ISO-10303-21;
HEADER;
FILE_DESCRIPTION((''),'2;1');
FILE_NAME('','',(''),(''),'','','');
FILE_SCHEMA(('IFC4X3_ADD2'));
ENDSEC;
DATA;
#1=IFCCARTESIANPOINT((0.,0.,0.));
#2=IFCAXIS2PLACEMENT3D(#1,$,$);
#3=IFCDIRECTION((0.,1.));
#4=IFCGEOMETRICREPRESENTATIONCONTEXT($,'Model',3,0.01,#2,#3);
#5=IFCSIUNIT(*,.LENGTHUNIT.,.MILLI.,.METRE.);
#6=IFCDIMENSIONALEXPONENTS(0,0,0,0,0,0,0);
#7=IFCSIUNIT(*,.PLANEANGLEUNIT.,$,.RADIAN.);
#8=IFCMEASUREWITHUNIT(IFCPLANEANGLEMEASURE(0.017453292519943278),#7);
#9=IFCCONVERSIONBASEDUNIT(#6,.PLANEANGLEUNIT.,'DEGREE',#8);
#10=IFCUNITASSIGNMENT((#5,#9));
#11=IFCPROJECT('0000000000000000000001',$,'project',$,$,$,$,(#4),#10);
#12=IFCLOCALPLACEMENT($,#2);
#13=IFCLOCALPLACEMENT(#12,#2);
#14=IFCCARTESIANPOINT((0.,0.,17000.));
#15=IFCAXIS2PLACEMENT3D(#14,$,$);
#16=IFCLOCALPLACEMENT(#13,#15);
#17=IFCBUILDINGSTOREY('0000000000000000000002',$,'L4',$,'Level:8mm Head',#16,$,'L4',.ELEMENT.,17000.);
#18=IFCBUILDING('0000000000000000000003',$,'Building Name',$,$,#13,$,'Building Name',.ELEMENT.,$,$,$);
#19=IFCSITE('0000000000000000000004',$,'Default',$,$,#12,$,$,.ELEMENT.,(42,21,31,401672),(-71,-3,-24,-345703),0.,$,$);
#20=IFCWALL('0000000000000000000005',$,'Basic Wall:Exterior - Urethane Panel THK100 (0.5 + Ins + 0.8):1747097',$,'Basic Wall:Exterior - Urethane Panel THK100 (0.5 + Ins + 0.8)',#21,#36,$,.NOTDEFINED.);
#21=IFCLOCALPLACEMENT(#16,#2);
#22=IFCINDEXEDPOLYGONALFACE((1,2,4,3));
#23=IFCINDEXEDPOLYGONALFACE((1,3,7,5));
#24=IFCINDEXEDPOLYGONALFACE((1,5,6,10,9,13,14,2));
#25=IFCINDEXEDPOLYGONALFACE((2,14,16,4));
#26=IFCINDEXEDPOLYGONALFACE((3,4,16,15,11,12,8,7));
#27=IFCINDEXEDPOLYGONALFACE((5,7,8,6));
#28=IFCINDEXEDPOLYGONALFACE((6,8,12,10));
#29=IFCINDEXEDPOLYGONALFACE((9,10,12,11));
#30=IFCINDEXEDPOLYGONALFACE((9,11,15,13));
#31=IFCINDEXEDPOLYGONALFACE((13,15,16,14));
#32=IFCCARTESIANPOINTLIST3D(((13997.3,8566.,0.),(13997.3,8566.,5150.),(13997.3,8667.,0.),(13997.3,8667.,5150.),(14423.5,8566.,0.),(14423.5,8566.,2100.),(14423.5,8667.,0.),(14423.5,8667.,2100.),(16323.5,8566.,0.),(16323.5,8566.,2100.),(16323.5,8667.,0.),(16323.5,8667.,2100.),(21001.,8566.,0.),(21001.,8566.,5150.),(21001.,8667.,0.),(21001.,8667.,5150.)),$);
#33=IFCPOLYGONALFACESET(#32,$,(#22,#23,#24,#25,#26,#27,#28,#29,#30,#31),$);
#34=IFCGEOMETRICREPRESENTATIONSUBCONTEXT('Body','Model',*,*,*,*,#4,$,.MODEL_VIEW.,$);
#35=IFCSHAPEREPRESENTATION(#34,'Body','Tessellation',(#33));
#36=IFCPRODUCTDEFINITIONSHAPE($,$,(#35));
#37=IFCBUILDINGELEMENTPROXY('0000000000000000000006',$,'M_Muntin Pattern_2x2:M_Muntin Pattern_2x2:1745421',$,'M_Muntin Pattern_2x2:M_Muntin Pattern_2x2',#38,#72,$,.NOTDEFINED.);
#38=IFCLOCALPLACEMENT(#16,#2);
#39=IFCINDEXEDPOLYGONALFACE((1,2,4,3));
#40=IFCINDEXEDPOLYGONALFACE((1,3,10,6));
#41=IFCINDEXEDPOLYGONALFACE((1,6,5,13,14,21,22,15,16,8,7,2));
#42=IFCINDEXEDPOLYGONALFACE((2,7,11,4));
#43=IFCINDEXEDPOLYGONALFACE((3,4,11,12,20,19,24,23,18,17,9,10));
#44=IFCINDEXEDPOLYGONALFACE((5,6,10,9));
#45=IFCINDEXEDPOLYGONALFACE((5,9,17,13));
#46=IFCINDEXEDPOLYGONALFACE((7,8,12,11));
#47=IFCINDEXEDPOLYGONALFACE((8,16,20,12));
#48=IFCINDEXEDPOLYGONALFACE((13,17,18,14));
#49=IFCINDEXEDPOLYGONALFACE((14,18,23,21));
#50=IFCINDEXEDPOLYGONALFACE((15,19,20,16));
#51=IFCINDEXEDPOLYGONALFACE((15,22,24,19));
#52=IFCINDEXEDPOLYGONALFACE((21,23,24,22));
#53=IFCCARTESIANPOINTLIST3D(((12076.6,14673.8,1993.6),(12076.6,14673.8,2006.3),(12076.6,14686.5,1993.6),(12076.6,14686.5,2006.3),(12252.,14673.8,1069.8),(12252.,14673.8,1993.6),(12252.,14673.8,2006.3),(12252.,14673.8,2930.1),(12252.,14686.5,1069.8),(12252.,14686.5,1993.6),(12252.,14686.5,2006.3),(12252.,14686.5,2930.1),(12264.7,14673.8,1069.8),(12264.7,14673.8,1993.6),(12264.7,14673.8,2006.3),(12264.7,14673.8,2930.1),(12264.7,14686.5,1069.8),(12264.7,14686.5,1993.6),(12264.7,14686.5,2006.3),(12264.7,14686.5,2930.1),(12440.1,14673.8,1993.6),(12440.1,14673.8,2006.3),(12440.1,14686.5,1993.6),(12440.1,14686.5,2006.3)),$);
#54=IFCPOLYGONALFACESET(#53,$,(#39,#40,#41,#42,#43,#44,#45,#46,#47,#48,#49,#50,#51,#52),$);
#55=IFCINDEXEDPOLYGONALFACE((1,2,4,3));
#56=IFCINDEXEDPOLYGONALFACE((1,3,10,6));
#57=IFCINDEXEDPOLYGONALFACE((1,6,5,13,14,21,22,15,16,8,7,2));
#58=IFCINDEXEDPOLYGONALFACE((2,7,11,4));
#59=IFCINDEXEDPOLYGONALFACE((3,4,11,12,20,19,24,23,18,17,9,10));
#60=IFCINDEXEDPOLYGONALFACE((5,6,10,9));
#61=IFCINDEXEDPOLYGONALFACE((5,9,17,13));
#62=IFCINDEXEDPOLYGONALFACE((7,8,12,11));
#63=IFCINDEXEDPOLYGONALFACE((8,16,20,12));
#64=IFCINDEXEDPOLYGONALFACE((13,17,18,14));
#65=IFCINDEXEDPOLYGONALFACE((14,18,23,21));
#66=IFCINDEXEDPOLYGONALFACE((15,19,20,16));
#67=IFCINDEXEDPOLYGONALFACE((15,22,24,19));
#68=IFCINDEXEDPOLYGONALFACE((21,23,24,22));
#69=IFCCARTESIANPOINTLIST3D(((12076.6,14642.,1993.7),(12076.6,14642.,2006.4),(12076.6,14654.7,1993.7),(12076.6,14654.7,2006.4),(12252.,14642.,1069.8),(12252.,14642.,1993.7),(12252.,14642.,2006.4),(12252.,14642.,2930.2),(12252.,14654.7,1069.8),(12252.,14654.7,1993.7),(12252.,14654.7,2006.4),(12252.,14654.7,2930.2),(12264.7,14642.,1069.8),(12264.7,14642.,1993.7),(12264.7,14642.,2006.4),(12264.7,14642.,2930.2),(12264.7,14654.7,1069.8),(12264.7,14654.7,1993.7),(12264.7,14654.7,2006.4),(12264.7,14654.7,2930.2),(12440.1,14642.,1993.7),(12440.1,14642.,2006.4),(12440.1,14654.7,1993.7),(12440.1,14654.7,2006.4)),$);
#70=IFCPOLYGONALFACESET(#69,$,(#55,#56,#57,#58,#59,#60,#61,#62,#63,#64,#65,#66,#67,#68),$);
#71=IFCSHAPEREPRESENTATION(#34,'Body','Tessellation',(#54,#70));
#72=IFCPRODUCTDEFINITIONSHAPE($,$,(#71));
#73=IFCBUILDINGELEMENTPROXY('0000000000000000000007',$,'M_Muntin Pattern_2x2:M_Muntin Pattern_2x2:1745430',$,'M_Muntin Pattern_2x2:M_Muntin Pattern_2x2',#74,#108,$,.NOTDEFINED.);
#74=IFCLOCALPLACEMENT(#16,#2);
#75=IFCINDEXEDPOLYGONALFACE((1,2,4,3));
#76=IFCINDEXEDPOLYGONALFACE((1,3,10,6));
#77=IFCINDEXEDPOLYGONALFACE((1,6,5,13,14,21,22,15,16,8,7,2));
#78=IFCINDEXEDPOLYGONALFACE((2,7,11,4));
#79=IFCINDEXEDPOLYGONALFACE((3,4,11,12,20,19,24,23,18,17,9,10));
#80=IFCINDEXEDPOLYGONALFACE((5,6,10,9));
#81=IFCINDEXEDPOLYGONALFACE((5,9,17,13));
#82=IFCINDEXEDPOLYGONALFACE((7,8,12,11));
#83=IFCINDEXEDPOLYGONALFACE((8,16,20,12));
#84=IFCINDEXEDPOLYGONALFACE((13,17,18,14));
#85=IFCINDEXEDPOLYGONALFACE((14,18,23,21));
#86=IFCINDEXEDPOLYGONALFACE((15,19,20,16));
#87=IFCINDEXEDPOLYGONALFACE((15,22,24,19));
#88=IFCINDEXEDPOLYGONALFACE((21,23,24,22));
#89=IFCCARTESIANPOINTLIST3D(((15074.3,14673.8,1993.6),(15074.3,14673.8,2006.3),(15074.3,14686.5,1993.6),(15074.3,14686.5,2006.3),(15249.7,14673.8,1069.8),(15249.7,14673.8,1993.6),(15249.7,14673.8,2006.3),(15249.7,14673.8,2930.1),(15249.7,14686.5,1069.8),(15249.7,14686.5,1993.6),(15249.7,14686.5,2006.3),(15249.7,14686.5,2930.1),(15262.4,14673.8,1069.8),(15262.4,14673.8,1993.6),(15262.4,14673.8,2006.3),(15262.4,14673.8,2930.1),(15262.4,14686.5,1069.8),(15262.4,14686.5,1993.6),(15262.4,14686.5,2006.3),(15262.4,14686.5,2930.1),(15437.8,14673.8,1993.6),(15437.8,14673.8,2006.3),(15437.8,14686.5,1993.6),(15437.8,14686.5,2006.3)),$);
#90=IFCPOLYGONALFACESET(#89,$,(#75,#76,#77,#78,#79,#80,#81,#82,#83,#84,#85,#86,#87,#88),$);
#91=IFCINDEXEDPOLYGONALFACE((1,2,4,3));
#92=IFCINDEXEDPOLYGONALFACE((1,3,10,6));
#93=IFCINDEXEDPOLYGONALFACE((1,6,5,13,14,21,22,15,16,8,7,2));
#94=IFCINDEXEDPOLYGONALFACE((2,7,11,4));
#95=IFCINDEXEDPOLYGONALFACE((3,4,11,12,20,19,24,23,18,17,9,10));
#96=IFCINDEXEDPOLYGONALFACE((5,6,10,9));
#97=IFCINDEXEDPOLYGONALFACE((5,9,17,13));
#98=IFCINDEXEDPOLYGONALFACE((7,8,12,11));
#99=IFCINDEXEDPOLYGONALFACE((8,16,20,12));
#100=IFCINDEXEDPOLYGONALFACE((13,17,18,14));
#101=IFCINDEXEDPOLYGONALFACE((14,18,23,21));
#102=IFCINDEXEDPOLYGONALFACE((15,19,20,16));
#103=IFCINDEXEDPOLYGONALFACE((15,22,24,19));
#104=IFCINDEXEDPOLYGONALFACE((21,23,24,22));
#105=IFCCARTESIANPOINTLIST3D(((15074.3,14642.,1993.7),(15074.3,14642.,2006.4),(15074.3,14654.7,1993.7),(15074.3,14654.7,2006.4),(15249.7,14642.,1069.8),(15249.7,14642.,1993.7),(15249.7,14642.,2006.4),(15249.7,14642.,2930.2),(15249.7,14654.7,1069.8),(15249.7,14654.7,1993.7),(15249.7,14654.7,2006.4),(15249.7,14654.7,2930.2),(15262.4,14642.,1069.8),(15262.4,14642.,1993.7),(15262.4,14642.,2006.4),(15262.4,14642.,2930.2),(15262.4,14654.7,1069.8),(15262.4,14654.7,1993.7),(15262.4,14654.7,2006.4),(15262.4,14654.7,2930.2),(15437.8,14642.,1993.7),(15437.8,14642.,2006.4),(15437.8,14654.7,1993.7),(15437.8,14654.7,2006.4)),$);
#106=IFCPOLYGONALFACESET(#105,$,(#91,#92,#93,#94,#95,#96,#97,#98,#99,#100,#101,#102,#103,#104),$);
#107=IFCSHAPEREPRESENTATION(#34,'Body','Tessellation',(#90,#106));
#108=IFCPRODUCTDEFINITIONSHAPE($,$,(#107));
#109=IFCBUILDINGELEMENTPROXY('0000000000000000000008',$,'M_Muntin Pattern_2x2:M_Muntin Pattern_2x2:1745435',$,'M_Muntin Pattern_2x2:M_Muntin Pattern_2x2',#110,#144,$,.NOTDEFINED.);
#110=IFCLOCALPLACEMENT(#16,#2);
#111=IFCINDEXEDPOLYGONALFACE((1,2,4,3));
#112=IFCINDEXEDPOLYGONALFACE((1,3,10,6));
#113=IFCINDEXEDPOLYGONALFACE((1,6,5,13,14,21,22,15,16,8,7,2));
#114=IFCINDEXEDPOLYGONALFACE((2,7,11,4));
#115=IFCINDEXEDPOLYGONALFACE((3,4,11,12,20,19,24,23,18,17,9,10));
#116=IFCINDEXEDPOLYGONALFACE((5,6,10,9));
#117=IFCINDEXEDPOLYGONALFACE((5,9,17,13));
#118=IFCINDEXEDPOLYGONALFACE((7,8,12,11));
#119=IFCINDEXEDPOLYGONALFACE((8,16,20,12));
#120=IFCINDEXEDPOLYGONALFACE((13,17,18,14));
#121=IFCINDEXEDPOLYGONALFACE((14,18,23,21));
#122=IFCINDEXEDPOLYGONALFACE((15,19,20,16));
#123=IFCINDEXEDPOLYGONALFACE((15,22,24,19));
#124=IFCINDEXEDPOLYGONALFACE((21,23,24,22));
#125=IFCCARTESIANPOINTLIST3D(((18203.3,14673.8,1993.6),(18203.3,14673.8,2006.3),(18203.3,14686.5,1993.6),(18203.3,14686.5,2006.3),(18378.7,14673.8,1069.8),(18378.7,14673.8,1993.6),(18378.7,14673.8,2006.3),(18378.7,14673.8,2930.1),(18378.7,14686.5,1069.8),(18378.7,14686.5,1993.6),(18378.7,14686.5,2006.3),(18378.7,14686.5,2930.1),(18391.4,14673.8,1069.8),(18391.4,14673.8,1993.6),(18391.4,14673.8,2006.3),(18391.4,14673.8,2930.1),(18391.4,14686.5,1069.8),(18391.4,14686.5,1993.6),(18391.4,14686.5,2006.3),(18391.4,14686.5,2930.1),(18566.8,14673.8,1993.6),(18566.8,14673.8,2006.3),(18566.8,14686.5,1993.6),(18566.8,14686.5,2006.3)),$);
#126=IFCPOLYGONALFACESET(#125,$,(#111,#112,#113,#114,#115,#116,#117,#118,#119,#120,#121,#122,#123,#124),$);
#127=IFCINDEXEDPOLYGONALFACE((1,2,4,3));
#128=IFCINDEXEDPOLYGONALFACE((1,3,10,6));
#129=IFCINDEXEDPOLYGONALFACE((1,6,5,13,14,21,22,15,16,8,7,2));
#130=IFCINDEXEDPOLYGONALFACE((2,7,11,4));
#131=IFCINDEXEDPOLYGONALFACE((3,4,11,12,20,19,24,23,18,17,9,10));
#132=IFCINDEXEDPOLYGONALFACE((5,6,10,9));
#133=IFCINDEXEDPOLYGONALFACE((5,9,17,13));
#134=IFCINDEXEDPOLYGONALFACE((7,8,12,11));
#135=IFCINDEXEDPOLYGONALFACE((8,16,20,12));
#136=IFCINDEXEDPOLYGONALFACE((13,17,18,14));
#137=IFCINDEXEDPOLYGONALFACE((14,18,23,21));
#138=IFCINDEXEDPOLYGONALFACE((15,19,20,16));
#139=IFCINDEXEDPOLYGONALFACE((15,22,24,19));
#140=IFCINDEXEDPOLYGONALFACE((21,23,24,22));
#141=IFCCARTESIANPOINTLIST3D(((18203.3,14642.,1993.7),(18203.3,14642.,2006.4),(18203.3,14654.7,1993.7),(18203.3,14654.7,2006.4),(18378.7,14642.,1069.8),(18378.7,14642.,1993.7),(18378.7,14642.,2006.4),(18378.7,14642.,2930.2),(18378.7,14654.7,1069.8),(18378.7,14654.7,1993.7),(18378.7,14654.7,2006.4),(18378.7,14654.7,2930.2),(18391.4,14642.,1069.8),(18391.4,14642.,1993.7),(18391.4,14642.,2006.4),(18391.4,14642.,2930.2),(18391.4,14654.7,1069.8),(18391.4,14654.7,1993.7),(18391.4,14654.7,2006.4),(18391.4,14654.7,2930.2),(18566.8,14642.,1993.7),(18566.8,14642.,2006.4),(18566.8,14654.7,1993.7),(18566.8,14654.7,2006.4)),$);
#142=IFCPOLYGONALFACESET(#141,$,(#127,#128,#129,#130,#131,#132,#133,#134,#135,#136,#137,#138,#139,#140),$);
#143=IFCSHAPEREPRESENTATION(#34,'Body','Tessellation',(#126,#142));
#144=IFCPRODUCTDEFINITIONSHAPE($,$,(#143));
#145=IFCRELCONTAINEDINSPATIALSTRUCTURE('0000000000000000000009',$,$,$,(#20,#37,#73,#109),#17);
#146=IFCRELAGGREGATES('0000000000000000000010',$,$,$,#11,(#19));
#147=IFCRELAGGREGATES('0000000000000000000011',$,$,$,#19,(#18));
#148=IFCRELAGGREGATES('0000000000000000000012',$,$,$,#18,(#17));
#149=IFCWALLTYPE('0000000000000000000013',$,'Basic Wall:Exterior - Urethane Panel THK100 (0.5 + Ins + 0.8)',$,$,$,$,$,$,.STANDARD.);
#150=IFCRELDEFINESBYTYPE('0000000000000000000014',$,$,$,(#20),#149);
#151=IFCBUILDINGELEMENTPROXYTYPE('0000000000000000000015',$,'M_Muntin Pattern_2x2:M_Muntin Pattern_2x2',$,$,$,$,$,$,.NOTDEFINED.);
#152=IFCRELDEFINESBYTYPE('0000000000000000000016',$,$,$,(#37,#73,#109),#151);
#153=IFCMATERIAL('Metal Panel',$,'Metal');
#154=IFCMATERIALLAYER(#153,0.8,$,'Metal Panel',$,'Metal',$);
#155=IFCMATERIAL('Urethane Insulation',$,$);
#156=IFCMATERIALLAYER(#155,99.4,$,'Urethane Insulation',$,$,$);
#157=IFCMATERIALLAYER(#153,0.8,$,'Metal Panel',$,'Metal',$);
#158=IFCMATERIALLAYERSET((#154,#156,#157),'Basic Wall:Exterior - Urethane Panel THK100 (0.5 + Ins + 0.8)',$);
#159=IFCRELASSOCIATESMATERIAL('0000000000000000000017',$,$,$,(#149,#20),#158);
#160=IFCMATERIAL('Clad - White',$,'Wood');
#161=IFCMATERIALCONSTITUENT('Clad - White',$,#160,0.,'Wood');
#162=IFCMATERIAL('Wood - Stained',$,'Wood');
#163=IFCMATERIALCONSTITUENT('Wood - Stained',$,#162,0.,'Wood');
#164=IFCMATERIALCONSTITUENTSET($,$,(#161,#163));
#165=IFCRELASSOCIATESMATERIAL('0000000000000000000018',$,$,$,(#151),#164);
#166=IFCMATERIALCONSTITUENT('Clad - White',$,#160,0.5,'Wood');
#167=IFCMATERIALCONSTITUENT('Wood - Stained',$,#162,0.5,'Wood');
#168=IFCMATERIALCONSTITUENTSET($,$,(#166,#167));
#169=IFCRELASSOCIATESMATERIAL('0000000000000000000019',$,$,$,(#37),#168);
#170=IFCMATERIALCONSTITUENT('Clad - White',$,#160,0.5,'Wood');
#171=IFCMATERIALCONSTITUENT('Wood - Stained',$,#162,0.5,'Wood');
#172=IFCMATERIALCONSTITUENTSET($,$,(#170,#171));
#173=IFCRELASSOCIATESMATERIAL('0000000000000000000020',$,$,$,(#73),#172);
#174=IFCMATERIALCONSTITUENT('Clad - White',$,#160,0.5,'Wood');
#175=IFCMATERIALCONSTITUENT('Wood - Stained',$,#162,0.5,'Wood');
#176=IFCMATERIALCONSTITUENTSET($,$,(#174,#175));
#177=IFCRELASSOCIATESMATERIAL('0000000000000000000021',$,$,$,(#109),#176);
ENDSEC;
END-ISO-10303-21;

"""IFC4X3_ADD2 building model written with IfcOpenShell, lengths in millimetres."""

from ifc_helpers import new_model, entity, si_unit, converted_unit, direction, frame, frame_2d, origin, place, context, subcontext, project, spatial, polyline, rectangle, outline, extrude, clip, bounded_halfspace, source, transform, mapped, material, layer, layer_set, constituent, constituent_set, type_object, type_shapes, element, save


model = new_model("IFC4X3_ADD2")

# Units and contexts
model_context = context("Model", 3, precision=0.01, world=origin(), true_north=direction((0.0, 1.0)))
body_context = subcontext(model_context, "Body", "Model", "MODEL_VIEW")
ifc_project = project(units=[si_unit("LENGTHUNIT", "METRE", prefix="MILLI"), converted_unit("PLANEANGLEUNIT", "DEGREE", entity("IfcPlaneAngleMeasure", 0.017453292519943278), si_unit("PLANEANGLEUNIT", "RADIAN"), dimensions=[0, 0, 0, 0, 0, 0, 0])], contexts=[model_context])

# Site, building, storey
site_placement = place(None, origin())
site = spatial("IfcSite", under=ifc_project, at=site_placement, Name="Default", CompositionType="ELEMENT", RefLatitude=(42, 21, 31, 401672), RefLongitude=(-71, -3, -24, -345703), RefElevation=0.0)
building_placement = place(site_placement, origin())
building = spatial("IfcBuilding", under=site, at=building_placement, Name="Building Name", LongName="Building Name", CompositionType="ELEMENT")
storey_placement = place(building_placement, frame((0.0, 0.0, 17000.0)))
storey = spatial("IfcBuildingStorey", under=building, at=storey_placement, Name="L4", ObjectType="Level:8mm Head", LongName="L4", CompositionType="ELEMENT", Elevation=17000.0)

# Shared definitions
ifc_material_1 = material(Name="Metal Panel", Category="Metal")
ifc_layer_1 = layer(ifc_material_1, 0.8, Name="Metal Panel", Category="Metal")
ifc_material_2 = material(Name="Urethane Insulation")
ifc_layer_2 = layer(ifc_material_2, 99.4, Name="Urethane Insulation")
ifc_layer_3 = layer(ifc_material_1, 0.8, Name="Metal Panel", Category="Metal")
ifc_layer_set_1 = layer_set([ifc_layer_1, ifc_layer_2, ifc_layer_3], Name="Basic Wall:Exterior - Urethane Panel THK100 (0.5 + Ins + 0.8)")
wall_type = type_object("IfcWallType", Name="Basic Wall:Exterior - Urethane Panel THK100 (0.5 + Ins + 0.8)", PredefinedType="STANDARD", material=ifc_layer_set_1)

# Wall, opening
wall_1_placement = place(storey_placement, frame((13997.3, 8616.5, 0.0)))
wall_1 = element("IfcWall", 1, at=wall_1_placement, inside=storey, type_object=wall_type, material=ifc_layer_set_1, Name="Basic Wall:Exterior - Urethane Panel THK100 (0.5 + Ins + 0.8):1747097", ObjectType="Basic Wall:Exterior - Urethane Panel THK100 (0.5 + Ins + 0.8)", PredefinedType="NOTDEFINED", context=body_context, shape_type="Clipping", body=[
    clip(extrude(rectangle(XDim=7003.7, YDim=101.0, at=frame_2d((3501.8, 0.0), x_axis=(-1.0, 0.0))), origin(), (0.0, 0.0, 1.0), 5150.0), bounded_halfspace(frame((0.0, -50.5, 5150.0), z_axis=(0.0, 0.0, -1.0), x_axis=(0.0, 1.0, 0.0)), True, frame((0.0, -50.5, 5150.0)), polyline([(0.0, 0.0), (7003.7, 0.0), (7003.7, 101.0), (0.0, 101.0), (0.0, 0.0)]))),
])
opening_1_placement = place(wall_1_placement, frame((2326.2, 50.5, 0.0)))
element("IfcOpeningElement", 2, at=opening_1_placement, cuts=wall_1, PredefinedType="OPENING", context=body_context, shape_type="SweptSolid", body=[
    extrude(rectangle(XDim=2100.0, YDim=1900.0, at=frame_2d((1050.0, 950.0), x_axis=(1.0, 0.0))), frame((0.0, 0.0, 0.0), z_axis=(0.0, -1.0, 0.0), x_axis=(0.0, 0.0, 1.0)), (0.0, 0.0, 1.0), 101.0),
])

# Building element proxies
ifc_material_3 = material(Name="Clad - White", Category="Wood")
ifc_constituent_1 = constituent(ifc_material_3, Name="Clad - White", Category="Wood", fraction=0.5)
ifc_material_4 = material(Name="Wood - Stained", Category="Wood")
ifc_constituent_2 = constituent(ifc_material_4, Name="Wood - Stained", Category="Wood", fraction=0.5)
ifc_constituent_set_1 = constituent_set(constituents=[ifc_constituent_1, ifc_constituent_2])
ifc_constituent_3 = constituent(ifc_material_3, Name="Clad - White", Category="Wood", fraction=0.0)
ifc_constituent_4 = constituent(ifc_material_4, Name="Wood - Stained", Category="Wood", fraction=0.0)
ifc_constituent_set_2 = constituent_set(constituents=[ifc_constituent_3, ifc_constituent_4])
building_element_proxy_type_1 = type_object("IfcBuildingElementProxyType", Name="M_Muntin Pattern_2x2:M_Muntin Pattern_2x2", PredefinedType="NOTDEFINED", material=ifc_constituent_set_2)
shared_shape_1 = source(origin(), body_context, "Body", "SweptSolid", [
    extrude(outline(polyline([(6.4, -6.4), (930.1, -6.4), (930.1, 6.3), (6.4, 6.3), (6.4, 181.7), (-6.3, 181.7), (-6.3, 6.3), (-930.2, 6.3), (-930.2, -6.4), (-6.3, -6.4), (-6.3, -181.7), (6.4, -181.7), (6.4, -6.4)])), frame((0.0, 9.5, 930.1), z_axis=(0.0, 1.0, 0.0), x_axis=(0.0, 0.0, 1.0)), (0.0, 0.0, 1.0), 12.7),
    extrude(outline(polyline([(6.4, -6.4), (930.2, -6.4), (930.2, 6.3), (6.4, 6.3), (6.4, 181.7), (-6.3, 181.7), (-6.3, 6.3), (-930.2, 6.3), (-930.2, -6.4), (-6.3, -6.4), (-6.3, -181.7), (6.4, -181.7), (6.4, -6.4)])), frame((0.0, -22.2, 930.2), z_axis=(0.0, 1.0, 0.0), x_axis=(0.0, 0.0, 1.0)), (0.0, 0.0, 1.0), 12.7),
])
type_shapes(building_element_proxy_type_1, [shared_shape_1])
proxy_1_placement = place(storey_placement, frame((12258.4, 14664.3, 1069.8)))
element("IfcBuildingElementProxy", 3, at=proxy_1_placement, inside=storey, type_object=building_element_proxy_type_1, material=ifc_constituent_set_1, Name="M_Muntin Pattern_2x2:M_Muntin Pattern_2x2:1745421", ObjectType="M_Muntin Pattern_2x2:M_Muntin Pattern_2x2", PredefinedType="NOTDEFINED", context=body_context, shape_type="MappedRepresentation", body=[
    mapped(shared_shape_1, transform((0.0, 0.0, 0.0), scale=1.0)),
])
ifc_constituent_5 = constituent(ifc_material_3, Name="Clad - White", Category="Wood", fraction=0.5)
ifc_constituent_6 = constituent(ifc_material_4, Name="Wood - Stained", Category="Wood", fraction=0.5)
ifc_constituent_set_3 = constituent_set(constituents=[ifc_constituent_5, ifc_constituent_6])
proxy_2_placement = place(storey_placement, frame((15256.0, 14664.3, 1069.8)))
element("IfcBuildingElementProxy", 4, at=proxy_2_placement, inside=storey, type_object=building_element_proxy_type_1, material=ifc_constituent_set_3, Name="M_Muntin Pattern_2x2:M_Muntin Pattern_2x2:1745430", ObjectType="M_Muntin Pattern_2x2:M_Muntin Pattern_2x2", PredefinedType="NOTDEFINED", context=body_context, shape_type="MappedRepresentation", body=[
    mapped(shared_shape_1, transform((0.0, 0.0, 0.0), scale=1.0)),
])
ifc_constituent_7 = constituent(ifc_material_3, Name="Clad - White", Category="Wood", fraction=0.5)
ifc_constituent_8 = constituent(ifc_material_4, Name="Wood - Stained", Category="Wood", fraction=0.5)
ifc_constituent_set_4 = constituent_set(constituents=[ifc_constituent_7, ifc_constituent_8])
proxy_3_placement = place(storey_placement, frame((18385.0, 14664.3, 1069.8)))
element("IfcBuildingElementProxy", 5, at=proxy_3_placement, inside=storey, type_object=building_element_proxy_type_1, material=ifc_constituent_set_4, Name="M_Muntin Pattern_2x2:M_Muntin Pattern_2x2:1745435", ObjectType="M_Muntin Pattern_2x2:M_Muntin Pattern_2x2", PredefinedType="NOTDEFINED", context=body_context, shape_type="MappedRepresentation", body=[
    mapped(shared_shape_1, transform((0.0, 0.0, 0.0), scale=1.0)),
])

save(model, "model.ifc")
